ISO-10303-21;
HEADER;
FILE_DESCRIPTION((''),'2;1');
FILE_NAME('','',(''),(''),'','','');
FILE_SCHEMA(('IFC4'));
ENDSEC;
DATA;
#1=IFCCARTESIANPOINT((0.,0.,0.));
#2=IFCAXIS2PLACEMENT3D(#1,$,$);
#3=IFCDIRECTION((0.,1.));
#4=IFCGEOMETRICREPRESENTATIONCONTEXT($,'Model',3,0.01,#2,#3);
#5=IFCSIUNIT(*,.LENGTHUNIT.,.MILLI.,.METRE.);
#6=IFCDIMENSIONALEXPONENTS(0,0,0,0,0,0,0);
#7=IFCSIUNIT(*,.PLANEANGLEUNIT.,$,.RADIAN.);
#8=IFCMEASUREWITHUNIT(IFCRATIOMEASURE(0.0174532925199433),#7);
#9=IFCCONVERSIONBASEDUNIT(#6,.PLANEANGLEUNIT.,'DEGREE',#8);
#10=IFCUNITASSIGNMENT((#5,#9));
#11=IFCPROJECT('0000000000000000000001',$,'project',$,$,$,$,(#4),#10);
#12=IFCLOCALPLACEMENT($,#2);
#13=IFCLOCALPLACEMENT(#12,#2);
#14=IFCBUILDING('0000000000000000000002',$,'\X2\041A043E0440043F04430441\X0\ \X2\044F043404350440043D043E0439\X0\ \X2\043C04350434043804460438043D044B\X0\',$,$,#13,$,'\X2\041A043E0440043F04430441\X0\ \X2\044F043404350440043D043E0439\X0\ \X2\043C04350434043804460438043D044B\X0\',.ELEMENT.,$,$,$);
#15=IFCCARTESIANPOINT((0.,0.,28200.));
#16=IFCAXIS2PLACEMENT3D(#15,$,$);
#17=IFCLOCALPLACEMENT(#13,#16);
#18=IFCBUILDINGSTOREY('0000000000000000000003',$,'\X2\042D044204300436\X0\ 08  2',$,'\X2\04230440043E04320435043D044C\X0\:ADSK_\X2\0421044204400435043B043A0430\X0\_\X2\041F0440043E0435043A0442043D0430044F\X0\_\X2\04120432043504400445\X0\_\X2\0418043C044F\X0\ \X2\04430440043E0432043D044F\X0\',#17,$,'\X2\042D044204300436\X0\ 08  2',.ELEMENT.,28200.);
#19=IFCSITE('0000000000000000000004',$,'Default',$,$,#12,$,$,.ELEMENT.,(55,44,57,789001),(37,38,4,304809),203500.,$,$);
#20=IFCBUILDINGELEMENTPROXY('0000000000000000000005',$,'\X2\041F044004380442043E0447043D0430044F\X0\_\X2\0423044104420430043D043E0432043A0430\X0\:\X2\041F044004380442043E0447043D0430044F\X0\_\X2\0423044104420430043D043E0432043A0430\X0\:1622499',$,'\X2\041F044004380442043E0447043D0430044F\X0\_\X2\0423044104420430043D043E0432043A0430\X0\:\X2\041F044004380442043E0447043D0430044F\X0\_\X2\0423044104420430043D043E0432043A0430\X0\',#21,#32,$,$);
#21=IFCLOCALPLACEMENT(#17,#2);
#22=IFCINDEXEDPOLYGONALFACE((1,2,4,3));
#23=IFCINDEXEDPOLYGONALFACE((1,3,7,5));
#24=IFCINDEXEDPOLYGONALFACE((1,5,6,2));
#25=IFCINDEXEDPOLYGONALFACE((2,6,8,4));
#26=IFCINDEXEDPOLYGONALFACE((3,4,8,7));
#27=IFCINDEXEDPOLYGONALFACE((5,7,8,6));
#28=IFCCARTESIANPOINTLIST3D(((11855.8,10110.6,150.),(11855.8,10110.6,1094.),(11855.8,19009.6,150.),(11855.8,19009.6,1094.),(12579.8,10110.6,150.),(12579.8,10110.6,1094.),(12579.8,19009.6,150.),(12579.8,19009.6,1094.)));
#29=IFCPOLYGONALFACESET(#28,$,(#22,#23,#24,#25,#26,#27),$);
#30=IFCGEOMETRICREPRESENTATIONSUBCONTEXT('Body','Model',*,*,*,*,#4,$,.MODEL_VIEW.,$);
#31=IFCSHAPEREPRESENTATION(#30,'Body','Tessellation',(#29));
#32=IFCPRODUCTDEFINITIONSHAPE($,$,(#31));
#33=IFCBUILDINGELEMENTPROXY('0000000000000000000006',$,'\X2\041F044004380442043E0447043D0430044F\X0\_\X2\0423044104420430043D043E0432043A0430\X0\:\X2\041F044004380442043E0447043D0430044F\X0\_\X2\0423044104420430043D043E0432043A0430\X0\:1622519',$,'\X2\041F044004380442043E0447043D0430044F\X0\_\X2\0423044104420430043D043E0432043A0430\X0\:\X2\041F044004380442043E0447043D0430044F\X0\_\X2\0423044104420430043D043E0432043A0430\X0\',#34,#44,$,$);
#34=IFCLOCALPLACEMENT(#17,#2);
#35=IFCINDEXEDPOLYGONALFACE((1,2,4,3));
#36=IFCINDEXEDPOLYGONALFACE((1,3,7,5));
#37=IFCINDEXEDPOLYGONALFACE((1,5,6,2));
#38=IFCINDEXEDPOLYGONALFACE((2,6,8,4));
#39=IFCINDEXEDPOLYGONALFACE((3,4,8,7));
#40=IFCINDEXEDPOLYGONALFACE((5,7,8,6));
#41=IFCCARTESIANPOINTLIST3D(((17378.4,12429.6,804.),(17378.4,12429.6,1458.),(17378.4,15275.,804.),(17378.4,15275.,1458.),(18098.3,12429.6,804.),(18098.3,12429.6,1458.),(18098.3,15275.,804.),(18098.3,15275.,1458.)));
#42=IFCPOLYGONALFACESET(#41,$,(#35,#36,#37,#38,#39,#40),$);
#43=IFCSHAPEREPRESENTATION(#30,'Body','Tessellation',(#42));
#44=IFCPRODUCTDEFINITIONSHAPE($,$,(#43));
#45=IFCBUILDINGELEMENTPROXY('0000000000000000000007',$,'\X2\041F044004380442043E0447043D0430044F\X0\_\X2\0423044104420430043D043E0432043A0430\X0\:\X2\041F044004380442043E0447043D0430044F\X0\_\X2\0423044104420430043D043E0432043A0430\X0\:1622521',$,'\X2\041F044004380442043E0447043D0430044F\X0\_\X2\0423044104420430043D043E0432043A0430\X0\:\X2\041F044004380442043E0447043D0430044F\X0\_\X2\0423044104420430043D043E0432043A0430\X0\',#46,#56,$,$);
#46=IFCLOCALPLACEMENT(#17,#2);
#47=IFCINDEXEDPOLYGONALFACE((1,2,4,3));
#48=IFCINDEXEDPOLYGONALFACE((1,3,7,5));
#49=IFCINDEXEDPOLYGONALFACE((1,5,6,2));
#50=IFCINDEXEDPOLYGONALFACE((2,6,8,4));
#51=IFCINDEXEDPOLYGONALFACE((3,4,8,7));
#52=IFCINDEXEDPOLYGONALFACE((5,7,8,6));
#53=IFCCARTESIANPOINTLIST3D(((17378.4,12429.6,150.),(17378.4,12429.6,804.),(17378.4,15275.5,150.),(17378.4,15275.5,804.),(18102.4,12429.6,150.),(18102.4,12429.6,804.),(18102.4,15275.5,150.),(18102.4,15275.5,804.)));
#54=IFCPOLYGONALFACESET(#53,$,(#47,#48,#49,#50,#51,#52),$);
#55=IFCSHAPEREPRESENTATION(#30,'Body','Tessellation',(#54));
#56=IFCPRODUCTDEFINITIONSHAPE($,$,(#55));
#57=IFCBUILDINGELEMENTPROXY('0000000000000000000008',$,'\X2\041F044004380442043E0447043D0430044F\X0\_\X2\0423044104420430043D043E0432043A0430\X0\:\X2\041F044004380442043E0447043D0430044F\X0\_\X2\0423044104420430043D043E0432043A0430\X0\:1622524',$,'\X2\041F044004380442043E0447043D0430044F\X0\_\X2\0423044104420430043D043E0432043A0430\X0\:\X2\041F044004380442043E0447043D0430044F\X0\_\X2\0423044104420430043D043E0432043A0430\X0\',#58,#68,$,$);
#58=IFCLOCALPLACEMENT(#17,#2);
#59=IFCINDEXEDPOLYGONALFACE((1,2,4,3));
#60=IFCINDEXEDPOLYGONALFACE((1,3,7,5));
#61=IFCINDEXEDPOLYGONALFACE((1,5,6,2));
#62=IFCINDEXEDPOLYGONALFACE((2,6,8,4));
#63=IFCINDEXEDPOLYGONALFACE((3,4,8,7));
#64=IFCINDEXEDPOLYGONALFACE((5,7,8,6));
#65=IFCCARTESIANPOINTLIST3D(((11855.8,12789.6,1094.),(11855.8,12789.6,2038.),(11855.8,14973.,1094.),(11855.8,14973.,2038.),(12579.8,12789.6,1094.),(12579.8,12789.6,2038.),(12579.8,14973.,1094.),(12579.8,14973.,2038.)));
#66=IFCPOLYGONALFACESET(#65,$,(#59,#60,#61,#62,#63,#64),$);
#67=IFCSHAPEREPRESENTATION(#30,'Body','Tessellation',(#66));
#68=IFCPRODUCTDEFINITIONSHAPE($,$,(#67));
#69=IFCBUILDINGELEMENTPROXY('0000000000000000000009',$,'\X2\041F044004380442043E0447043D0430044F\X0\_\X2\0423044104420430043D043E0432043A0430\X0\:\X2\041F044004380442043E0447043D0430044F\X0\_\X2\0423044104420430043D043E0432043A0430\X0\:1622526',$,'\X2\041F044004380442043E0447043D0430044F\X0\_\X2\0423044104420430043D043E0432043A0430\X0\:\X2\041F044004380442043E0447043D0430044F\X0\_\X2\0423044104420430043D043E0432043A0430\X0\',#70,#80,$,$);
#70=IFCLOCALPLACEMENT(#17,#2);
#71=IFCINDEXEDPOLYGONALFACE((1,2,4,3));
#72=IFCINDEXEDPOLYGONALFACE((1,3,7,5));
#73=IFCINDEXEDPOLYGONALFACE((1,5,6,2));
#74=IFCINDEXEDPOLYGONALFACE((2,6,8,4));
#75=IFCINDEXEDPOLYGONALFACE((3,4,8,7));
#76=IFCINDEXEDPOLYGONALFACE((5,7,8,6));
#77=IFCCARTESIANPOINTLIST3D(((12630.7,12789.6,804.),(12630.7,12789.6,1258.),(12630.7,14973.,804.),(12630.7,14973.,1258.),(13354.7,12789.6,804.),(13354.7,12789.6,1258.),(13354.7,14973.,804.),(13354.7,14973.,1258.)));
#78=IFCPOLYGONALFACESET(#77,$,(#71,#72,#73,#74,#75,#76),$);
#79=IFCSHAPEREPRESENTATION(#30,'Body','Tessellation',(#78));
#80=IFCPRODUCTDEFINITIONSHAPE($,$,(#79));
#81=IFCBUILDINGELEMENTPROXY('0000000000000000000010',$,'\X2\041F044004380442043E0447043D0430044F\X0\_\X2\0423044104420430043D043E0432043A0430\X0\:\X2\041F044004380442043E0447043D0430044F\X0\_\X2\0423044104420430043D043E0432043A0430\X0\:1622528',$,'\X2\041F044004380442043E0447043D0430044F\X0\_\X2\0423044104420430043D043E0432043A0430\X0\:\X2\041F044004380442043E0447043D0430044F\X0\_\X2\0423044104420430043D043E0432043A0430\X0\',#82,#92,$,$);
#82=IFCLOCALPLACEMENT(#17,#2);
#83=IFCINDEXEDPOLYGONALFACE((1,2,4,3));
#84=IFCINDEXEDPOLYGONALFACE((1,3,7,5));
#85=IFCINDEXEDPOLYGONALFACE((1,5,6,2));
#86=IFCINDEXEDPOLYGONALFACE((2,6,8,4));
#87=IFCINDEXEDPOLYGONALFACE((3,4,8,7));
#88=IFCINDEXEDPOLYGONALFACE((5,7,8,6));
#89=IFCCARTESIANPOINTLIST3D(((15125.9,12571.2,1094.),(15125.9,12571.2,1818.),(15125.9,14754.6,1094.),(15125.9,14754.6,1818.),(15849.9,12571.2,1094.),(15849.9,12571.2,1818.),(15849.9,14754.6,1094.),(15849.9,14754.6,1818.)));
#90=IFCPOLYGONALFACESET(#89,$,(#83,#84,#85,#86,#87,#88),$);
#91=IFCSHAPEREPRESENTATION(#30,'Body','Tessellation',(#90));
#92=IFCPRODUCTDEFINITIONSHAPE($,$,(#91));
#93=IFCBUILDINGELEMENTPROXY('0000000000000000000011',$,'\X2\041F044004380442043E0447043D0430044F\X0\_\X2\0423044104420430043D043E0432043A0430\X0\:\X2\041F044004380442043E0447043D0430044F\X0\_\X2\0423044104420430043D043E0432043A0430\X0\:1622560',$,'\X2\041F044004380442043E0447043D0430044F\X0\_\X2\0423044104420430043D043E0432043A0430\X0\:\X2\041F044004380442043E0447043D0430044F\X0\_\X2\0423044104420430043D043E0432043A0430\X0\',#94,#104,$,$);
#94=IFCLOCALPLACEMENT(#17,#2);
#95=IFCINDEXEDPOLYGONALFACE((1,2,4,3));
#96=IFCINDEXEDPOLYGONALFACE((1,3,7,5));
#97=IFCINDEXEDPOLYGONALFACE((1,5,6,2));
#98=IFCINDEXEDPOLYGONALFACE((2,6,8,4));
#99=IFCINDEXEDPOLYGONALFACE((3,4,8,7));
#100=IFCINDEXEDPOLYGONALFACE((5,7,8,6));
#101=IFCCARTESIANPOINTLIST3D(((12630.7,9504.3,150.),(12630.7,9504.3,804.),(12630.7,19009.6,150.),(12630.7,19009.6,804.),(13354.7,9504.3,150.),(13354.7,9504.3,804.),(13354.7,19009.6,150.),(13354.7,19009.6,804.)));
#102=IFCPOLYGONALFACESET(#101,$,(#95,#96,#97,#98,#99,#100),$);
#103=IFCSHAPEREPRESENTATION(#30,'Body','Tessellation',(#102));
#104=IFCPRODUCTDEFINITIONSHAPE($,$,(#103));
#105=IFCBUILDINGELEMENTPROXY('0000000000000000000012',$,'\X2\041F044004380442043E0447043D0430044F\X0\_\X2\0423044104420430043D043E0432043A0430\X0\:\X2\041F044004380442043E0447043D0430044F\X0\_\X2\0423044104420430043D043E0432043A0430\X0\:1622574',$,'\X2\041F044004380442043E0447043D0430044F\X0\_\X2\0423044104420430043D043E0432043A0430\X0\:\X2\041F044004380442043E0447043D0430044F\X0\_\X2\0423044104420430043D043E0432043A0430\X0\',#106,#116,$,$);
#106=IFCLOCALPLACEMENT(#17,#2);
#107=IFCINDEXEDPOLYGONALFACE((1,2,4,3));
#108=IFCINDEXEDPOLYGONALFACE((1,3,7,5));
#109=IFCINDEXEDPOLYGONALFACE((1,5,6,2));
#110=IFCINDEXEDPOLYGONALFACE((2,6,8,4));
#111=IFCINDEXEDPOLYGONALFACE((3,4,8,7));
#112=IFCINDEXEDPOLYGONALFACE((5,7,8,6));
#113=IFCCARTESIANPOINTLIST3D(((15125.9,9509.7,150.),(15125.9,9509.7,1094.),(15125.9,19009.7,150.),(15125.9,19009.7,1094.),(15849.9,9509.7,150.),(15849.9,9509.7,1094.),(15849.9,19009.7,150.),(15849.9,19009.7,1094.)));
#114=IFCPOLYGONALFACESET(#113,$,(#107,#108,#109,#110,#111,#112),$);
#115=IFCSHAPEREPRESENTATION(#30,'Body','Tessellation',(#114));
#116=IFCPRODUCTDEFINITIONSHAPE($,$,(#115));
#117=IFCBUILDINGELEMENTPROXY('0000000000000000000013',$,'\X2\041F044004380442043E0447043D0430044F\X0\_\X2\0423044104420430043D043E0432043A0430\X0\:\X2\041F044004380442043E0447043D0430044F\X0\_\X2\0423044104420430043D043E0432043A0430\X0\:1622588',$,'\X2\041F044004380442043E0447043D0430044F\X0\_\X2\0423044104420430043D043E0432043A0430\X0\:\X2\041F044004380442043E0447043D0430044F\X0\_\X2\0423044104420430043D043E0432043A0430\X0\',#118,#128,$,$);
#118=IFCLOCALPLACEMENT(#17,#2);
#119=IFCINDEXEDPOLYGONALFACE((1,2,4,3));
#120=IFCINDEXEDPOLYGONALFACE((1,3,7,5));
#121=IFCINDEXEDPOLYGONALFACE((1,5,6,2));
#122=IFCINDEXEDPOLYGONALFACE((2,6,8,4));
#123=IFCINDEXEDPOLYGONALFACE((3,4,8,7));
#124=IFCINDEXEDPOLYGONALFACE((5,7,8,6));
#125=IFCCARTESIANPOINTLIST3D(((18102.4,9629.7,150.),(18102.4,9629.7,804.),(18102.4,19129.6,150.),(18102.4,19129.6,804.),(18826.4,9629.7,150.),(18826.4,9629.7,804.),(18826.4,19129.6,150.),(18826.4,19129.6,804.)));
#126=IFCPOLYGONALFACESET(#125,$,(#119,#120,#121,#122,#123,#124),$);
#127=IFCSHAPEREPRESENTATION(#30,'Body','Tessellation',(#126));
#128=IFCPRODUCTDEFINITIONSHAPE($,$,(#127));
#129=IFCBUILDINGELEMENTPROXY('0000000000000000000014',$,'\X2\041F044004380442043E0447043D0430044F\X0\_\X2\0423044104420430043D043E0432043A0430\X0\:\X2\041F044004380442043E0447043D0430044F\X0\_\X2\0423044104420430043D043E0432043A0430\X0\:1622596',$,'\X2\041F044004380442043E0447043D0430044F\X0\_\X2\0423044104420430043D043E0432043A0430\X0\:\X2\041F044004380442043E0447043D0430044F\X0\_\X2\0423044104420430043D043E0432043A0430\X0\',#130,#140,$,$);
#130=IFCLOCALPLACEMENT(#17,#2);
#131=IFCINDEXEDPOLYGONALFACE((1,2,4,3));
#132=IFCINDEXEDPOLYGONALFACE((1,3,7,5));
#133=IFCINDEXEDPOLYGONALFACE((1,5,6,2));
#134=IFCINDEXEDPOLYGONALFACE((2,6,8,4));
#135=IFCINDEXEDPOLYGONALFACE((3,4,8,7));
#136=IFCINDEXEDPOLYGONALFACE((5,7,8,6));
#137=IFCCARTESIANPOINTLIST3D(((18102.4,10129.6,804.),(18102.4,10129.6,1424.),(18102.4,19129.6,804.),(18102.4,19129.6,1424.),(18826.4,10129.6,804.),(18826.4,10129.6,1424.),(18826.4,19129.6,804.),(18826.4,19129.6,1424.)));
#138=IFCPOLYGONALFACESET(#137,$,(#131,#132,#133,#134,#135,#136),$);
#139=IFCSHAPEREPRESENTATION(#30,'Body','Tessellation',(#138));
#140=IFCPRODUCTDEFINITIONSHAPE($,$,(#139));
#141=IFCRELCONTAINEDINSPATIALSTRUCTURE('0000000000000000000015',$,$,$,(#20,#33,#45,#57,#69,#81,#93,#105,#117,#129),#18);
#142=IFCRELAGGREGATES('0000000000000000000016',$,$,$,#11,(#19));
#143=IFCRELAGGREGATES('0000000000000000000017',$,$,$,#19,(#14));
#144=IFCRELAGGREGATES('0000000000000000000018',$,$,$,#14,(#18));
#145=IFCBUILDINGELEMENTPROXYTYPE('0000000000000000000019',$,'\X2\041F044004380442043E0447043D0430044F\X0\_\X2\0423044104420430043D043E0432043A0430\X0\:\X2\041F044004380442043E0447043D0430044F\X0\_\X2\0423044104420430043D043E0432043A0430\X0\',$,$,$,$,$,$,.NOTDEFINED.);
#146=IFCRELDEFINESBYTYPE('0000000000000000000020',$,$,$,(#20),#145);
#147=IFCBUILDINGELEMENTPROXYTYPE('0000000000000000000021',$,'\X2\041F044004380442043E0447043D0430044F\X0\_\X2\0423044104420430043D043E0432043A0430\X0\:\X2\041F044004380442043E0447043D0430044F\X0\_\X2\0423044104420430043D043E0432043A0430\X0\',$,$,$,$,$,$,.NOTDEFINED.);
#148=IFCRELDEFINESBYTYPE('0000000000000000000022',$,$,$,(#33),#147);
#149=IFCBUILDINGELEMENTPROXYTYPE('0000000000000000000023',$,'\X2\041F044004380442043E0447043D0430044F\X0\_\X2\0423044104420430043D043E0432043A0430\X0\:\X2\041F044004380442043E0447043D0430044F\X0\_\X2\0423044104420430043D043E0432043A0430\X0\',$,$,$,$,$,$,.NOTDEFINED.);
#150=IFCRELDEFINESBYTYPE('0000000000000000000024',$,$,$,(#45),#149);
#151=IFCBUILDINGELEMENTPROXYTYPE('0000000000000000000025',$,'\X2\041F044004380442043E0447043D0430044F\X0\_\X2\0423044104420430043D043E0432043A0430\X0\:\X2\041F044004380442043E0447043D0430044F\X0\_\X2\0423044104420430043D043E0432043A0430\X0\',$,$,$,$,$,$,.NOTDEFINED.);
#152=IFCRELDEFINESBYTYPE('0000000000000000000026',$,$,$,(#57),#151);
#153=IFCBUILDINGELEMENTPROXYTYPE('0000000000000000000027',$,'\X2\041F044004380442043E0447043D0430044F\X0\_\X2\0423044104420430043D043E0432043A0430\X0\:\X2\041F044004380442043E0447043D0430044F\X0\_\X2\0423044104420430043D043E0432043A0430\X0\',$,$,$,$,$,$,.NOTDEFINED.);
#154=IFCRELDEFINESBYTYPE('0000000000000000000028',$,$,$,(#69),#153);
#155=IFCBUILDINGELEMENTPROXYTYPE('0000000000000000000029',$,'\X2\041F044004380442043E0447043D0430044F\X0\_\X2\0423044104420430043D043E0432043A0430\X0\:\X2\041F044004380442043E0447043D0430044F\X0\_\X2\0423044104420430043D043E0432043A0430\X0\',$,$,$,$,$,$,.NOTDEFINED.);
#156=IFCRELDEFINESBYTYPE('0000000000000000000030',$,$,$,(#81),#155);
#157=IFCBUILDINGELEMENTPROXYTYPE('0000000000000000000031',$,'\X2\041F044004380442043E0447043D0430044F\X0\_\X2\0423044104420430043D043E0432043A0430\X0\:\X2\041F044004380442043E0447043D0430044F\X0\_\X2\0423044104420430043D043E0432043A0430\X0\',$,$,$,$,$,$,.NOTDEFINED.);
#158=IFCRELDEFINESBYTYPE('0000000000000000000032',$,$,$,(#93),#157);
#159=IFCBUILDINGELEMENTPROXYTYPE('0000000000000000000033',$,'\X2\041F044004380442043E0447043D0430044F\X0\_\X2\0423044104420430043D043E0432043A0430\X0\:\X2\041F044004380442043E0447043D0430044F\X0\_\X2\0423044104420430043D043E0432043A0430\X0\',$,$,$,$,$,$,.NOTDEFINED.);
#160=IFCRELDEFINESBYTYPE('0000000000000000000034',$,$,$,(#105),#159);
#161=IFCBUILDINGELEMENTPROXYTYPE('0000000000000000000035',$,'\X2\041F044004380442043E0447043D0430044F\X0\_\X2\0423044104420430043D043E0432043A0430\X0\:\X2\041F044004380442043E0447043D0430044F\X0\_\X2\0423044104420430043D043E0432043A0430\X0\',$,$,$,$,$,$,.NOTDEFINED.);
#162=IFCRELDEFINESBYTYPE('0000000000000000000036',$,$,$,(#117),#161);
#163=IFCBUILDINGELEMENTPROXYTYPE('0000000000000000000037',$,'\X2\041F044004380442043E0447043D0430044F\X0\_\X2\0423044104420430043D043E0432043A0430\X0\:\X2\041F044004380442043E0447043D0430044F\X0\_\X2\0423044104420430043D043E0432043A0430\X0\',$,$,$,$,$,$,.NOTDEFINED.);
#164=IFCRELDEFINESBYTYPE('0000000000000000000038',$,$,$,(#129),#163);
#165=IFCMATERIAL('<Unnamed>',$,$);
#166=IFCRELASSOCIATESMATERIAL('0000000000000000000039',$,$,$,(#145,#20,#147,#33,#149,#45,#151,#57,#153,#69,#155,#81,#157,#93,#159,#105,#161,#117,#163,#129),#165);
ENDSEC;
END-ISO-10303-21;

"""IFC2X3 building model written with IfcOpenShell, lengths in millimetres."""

from ifc_helpers import new_model, entity, si_unit, converted_unit, direction, frame, origin, origin_2d_with_axis, place, context, subcontext, project, spatial, rectangle, extrude, source, transform, mapped, material, type_object, type_shapes, element, save


model = new_model("IFC2X3")

# Units and contexts
model_context = context("Model", 3, precision=0.01, world=origin(), true_north=direction((0.0, 1.0)))
body_context = subcontext(model_context, "Body", "Model", "MODEL_VIEW")
ifc_project = project(units=[si_unit("LENGTHUNIT", "METRE", prefix="MILLI"), converted_unit("PLANEANGLEUNIT", "DEGREE", entity("IfcRatioMeasure", 0.0174532925199433), si_unit("PLANEANGLEUNIT", "RADIAN"), dimensions=[0, 0, 0, 0, 0, 0, 0])], contexts=[model_context])

# Site, building, storey
site_placement = place(None, origin())
site = spatial("IfcSite", under=ifc_project, at=site_placement, Name="Default", CompositionType="ELEMENT", RefLatitude=(55, 44, 57, 789001), RefLongitude=(37, 38, 4, 304809), RefElevation=203500.0)
building_placement = place(site_placement, origin())
building = spatial("IfcBuilding", under=site, at=building_placement, Name="Корпус ядерной медицины", LongName="Корпус ядерной медицины", CompositionType="ELEMENT")
storey_placement = place(building_placement, frame((0.0, 0.0, 28200.0)))
storey = spatial("IfcBuildingStorey", under=building, at=storey_placement, Name="Этаж 08  2", ObjectType="Уровень:ADSK_Стрелка_Проектная_Вверх_Имя уровня", LongName="Этаж 08  2", CompositionType="ELEMENT", Elevation=28200.0)

# Shared definitions
ifc_material = material(Name="<Unnamed>")

# Building element proxies
building_element_proxy_type_1 = type_object("IfcBuildingElementProxyType", Name="Приточная_Установка:Приточная_Установка", PredefinedType="NOTDEFINED", material=ifc_material)
shared_shape_1 = source(origin(), body_context, "Body", "SweptSolid", [
    extrude(rectangle(XDim=724.0, YDim=8899.0, at=origin_2d_with_axis()), origin(), (0.0, 0.0, 1.0), 944.0),
])
type_shapes(building_element_proxy_type_1, [shared_shape_1])
proxy_1_placement = place(storey_placement, frame((12217.8, 14560.1, 150.0)))
element("IfcBuildingElementProxy", 1, at=proxy_1_placement, inside=storey, type_object=building_element_proxy_type_1, material=ifc_material, Name="Приточная_Установка:Приточная_Установка:1622499", ObjectType="Приточная_Установка:Приточная_Установка", context=body_context, shape_type="MappedRepresentation", body=[
    mapped(shared_shape_1, transform((0.0, 0.0, 0.0), scale=1.0)),
])
building_element_proxy_type_2 = type_object("IfcBuildingElementProxyType", Name="Приточная_Установка:Приточная_Установка", PredefinedType="NOTDEFINED", material=ifc_material)
shared_shape_2 = source(origin(), body_context, "Body", "SweptSolid", [
    extrude(rectangle(XDim=720.0, YDim=2845.4, at=origin_2d_with_axis()), origin(), (0.0, 0.0, 1.0), 654.0),
])
type_shapes(building_element_proxy_type_2, [shared_shape_2])
proxy_2_placement = place(storey_placement, frame((17738.4, 13852.3, 804.0)))
element("IfcBuildingElementProxy", 2, at=proxy_2_placement, inside=storey, type_object=building_element_proxy_type_2, material=ifc_material, Name="Приточная_Установка:Приточная_Установка:1622519", ObjectType="Приточная_Установка:Приточная_Установка", context=body_context, shape_type="MappedRepresentation", body=[
    mapped(shared_shape_2, transform((0.0, 0.0, 0.0), scale=1.0)),
])
building_element_proxy_type_3 = type_object("IfcBuildingElementProxyType", Name="Приточная_Установка:Приточная_Установка", PredefinedType="NOTDEFINED", material=ifc_material)
shared_shape_3 = source(origin(), body_context, "Body", "SweptSolid", [
    extrude(rectangle(XDim=724.0, YDim=2845.9, at=origin_2d_with_axis()), origin(), (0.0, 0.0, 1.0), 654.0),
])
type_shapes(building_element_proxy_type_3, [shared_shape_3])
proxy_3_placement = place(storey_placement, frame((17740.4, 13852.6, 150.0)))
element("IfcBuildingElementProxy", 3, at=proxy_3_placement, inside=storey, type_object=building_element_proxy_type_3, material=ifc_material, Name="Приточная_Установка:Приточная_Установка:1622521", ObjectType="Приточная_Установка:Приточная_Установка", context=body_context, shape_type="MappedRepresentation", body=[
    mapped(shared_shape_3, transform((0.0, 0.0, 0.0), scale=1.0)),
])
building_element_proxy_type_4 = type_object("IfcBuildingElementProxyType", Name="Приточная_Установка:Приточная_Установка", PredefinedType="NOTDEFINED", material=ifc_material)
shared_shape_4 = source(origin(), body_context, "Body", "SweptSolid", [
    extrude(rectangle(XDim=724.0, YDim=2183.4, at=origin_2d_with_axis()), origin(), (0.0, 0.0, 1.0), 944.0),
])
type_shapes(building_element_proxy_type_4, [shared_shape_4])
proxy_4_placement = place(storey_placement, frame((12217.8, 13881.3, 1094.0)))
element("IfcBuildingElementProxy", 4, at=proxy_4_placement, inside=storey, type_object=building_element_proxy_type_4, material=ifc_material, Name="Приточная_Установка:Приточная_Установка:1622524", ObjectType="Приточная_Установка:Приточная_Установка", context=body_context, shape_type="MappedRepresentation", body=[
    mapped(shared_shape_4, transform((0.0, 0.0, 0.0), scale=1.0)),
])
building_element_proxy_type_5 = type_object("IfcBuildingElementProxyType", Name="Приточная_Установка:Приточная_Установка", PredefinedType="NOTDEFINED", material=ifc_material)
shared_shape_5 = source(origin(), body_context, "Body", "SweptSolid", [
    extrude(rectangle(XDim=724.0, YDim=2183.4, at=origin_2d_with_axis()), origin(), (0.0, 0.0, 1.0), 454.0),
])
type_shapes(building_element_proxy_type_5, [shared_shape_5])
proxy_5_placement = place(storey_placement, frame((12992.7, 13881.3, 804.0)))
element("IfcBuildingElementProxy", 5, at=proxy_5_placement, inside=storey, type_object=building_element_proxy_type_5, material=ifc_material, Name="Приточная_Установка:Приточная_Установка:1622526", ObjectType="Приточная_Установка:Приточная_Установка", context=body_context, shape_type="MappedRepresentation", body=[
    mapped(shared_shape_5, transform((0.0, 0.0, 0.0), scale=1.0)),
])
building_element_proxy_type_6 = type_object("IfcBuildingElementProxyType", Name="Приточная_Установка:Приточная_Установка", PredefinedType="NOTDEFINED", material=ifc_material)
shared_shape_6 = source(origin(), body_context, "Body", "SweptSolid", [
    extrude(rectangle(XDim=724.0, YDim=2183.4, at=origin_2d_with_axis()), origin(), (0.0, 0.0, 1.0), 724.0),
])
type_shapes(building_element_proxy_type_6, [shared_shape_6])
proxy_6_placement = place(storey_placement, frame((15487.9, 13662.9, 1094.0)))
element("IfcBuildingElementProxy", 6, at=proxy_6_placement, inside=storey, type_object=building_element_proxy_type_6, material=ifc_material, Name="Приточная_Установка:Приточная_Установка:1622528", ObjectType="Приточная_Установка:Приточная_Установка", context=body_context, shape_type="MappedRepresentation", body=[
    mapped(shared_shape_6, transform((0.0, 0.0, 0.0), scale=1.0)),
])
building_element_proxy_type_7 = type_object("IfcBuildingElementProxyType", Name="Приточная_Установка:Приточная_Установка", PredefinedType="NOTDEFINED", material=ifc_material)
shared_shape_7 = source(origin(), body_context, "Body", "SweptSolid", [
    extrude(rectangle(XDim=724.0, YDim=9505.3, at=origin_2d_with_axis()), origin(), (0.0, 0.0, 1.0), 654.0),
])
type_shapes(building_element_proxy_type_7, [shared_shape_7])
proxy_7_placement = place(storey_placement, frame((12992.7, 14257.0, 150.0)))
element("IfcBuildingElementProxy", 7, at=proxy_7_placement, inside=storey, type_object=building_element_proxy_type_7, material=ifc_material, Name="Приточная_Установка:Приточная_Установка:1622560", ObjectType="Приточная_Установка:Приточная_Установка", context=body_context, shape_type="MappedRepresentation", body=[
    mapped(shared_shape_7, transform((0.0, 0.0, 0.0), scale=1.0)),
])
building_element_proxy_type_8 = type_object("IfcBuildingElementProxyType", Name="Приточная_Установка:Приточная_Установка", PredefinedType="NOTDEFINED", material=ifc_material)
shared_shape_8 = source(origin(), body_context, "Body", "SweptSolid", [
    extrude(rectangle(XDim=724.0, YDim=9500.0, at=origin_2d_with_axis()), origin(), (0.0, 0.0, 1.0), 944.0),
])
type_shapes(building_element_proxy_type_8, [shared_shape_8])
proxy_8_placement = place(storey_placement, frame((15487.9, 14259.7, 150.0)))
element("IfcBuildingElementProxy", 8, at=proxy_8_placement, inside=storey, type_object=building_element_proxy_type_8, material=ifc_material, Name="Приточная_Установка:Приточная_Установка:1622574", ObjectType="Приточная_Установка:Приточная_Установка", context=body_context, shape_type="MappedRepresentation", body=[
    mapped(shared_shape_8, transform((0.0, 0.0, 0.0), scale=1.0)),
])
building_element_proxy_type_9 = type_object("IfcBuildingElementProxyType", Name="Приточная_Установка:Приточная_Установка", PredefinedType="NOTDEFINED", material=ifc_material)
shared_shape_9 = source(origin(), body_context, "Body", "SweptSolid", [
    extrude(rectangle(XDim=724.0, YDim=9500.0, at=origin_2d_with_axis()), origin(), (0.0, 0.0, 1.0), 654.0),
])
type_shapes(building_element_proxy_type_9, [shared_shape_9])
proxy_9_placement = place(storey_placement, frame((18464.4, 14379.6, 150.0)))
element("IfcBuildingElementProxy", 9, at=proxy_9_placement, inside=storey, type_object=building_element_proxy_type_9, material=ifc_material, Name="Приточная_Установка:Приточная_Установка:1622588", ObjectType="Приточная_Установка:Приточная_Установка", context=body_context, shape_type="MappedRepresentation", body=[
    mapped(shared_shape_9, transform((0.0, 0.0, 0.0), scale=1.0)),
])
building_element_proxy_type_10 = type_object("IfcBuildingElementProxyType", Name="Приточная_Установка:Приточная_Установка", PredefinedType="NOTDEFINED", material=ifc_material)
shared_shape_10 = source(origin(), body_context, "Body", "SweptSolid", [
    extrude(rectangle(XDim=724.0, YDim=9000.0, at=origin_2d_with_axis()), origin(), (0.0, 0.0, 1.0), 620.0),
])
type_shapes(building_element_proxy_type_10, [shared_shape_10])
proxy_10_placement = place(storey_placement, frame((18464.4, 14629.6, 804.0)))
element("IfcBuildingElementProxy", 10, at=proxy_10_placement, inside=storey, type_object=building_element_proxy_type_10, material=ifc_material, Name="Приточная_Установка:Приточная_Установка:1622596", ObjectType="Приточная_Установка:Приточная_Установка", context=body_context, shape_type="MappedRepresentation", body=[
    mapped(shared_shape_10, transform((0.0, 0.0, 0.0), scale=1.0)),
])

save(model, "model.ifc")
